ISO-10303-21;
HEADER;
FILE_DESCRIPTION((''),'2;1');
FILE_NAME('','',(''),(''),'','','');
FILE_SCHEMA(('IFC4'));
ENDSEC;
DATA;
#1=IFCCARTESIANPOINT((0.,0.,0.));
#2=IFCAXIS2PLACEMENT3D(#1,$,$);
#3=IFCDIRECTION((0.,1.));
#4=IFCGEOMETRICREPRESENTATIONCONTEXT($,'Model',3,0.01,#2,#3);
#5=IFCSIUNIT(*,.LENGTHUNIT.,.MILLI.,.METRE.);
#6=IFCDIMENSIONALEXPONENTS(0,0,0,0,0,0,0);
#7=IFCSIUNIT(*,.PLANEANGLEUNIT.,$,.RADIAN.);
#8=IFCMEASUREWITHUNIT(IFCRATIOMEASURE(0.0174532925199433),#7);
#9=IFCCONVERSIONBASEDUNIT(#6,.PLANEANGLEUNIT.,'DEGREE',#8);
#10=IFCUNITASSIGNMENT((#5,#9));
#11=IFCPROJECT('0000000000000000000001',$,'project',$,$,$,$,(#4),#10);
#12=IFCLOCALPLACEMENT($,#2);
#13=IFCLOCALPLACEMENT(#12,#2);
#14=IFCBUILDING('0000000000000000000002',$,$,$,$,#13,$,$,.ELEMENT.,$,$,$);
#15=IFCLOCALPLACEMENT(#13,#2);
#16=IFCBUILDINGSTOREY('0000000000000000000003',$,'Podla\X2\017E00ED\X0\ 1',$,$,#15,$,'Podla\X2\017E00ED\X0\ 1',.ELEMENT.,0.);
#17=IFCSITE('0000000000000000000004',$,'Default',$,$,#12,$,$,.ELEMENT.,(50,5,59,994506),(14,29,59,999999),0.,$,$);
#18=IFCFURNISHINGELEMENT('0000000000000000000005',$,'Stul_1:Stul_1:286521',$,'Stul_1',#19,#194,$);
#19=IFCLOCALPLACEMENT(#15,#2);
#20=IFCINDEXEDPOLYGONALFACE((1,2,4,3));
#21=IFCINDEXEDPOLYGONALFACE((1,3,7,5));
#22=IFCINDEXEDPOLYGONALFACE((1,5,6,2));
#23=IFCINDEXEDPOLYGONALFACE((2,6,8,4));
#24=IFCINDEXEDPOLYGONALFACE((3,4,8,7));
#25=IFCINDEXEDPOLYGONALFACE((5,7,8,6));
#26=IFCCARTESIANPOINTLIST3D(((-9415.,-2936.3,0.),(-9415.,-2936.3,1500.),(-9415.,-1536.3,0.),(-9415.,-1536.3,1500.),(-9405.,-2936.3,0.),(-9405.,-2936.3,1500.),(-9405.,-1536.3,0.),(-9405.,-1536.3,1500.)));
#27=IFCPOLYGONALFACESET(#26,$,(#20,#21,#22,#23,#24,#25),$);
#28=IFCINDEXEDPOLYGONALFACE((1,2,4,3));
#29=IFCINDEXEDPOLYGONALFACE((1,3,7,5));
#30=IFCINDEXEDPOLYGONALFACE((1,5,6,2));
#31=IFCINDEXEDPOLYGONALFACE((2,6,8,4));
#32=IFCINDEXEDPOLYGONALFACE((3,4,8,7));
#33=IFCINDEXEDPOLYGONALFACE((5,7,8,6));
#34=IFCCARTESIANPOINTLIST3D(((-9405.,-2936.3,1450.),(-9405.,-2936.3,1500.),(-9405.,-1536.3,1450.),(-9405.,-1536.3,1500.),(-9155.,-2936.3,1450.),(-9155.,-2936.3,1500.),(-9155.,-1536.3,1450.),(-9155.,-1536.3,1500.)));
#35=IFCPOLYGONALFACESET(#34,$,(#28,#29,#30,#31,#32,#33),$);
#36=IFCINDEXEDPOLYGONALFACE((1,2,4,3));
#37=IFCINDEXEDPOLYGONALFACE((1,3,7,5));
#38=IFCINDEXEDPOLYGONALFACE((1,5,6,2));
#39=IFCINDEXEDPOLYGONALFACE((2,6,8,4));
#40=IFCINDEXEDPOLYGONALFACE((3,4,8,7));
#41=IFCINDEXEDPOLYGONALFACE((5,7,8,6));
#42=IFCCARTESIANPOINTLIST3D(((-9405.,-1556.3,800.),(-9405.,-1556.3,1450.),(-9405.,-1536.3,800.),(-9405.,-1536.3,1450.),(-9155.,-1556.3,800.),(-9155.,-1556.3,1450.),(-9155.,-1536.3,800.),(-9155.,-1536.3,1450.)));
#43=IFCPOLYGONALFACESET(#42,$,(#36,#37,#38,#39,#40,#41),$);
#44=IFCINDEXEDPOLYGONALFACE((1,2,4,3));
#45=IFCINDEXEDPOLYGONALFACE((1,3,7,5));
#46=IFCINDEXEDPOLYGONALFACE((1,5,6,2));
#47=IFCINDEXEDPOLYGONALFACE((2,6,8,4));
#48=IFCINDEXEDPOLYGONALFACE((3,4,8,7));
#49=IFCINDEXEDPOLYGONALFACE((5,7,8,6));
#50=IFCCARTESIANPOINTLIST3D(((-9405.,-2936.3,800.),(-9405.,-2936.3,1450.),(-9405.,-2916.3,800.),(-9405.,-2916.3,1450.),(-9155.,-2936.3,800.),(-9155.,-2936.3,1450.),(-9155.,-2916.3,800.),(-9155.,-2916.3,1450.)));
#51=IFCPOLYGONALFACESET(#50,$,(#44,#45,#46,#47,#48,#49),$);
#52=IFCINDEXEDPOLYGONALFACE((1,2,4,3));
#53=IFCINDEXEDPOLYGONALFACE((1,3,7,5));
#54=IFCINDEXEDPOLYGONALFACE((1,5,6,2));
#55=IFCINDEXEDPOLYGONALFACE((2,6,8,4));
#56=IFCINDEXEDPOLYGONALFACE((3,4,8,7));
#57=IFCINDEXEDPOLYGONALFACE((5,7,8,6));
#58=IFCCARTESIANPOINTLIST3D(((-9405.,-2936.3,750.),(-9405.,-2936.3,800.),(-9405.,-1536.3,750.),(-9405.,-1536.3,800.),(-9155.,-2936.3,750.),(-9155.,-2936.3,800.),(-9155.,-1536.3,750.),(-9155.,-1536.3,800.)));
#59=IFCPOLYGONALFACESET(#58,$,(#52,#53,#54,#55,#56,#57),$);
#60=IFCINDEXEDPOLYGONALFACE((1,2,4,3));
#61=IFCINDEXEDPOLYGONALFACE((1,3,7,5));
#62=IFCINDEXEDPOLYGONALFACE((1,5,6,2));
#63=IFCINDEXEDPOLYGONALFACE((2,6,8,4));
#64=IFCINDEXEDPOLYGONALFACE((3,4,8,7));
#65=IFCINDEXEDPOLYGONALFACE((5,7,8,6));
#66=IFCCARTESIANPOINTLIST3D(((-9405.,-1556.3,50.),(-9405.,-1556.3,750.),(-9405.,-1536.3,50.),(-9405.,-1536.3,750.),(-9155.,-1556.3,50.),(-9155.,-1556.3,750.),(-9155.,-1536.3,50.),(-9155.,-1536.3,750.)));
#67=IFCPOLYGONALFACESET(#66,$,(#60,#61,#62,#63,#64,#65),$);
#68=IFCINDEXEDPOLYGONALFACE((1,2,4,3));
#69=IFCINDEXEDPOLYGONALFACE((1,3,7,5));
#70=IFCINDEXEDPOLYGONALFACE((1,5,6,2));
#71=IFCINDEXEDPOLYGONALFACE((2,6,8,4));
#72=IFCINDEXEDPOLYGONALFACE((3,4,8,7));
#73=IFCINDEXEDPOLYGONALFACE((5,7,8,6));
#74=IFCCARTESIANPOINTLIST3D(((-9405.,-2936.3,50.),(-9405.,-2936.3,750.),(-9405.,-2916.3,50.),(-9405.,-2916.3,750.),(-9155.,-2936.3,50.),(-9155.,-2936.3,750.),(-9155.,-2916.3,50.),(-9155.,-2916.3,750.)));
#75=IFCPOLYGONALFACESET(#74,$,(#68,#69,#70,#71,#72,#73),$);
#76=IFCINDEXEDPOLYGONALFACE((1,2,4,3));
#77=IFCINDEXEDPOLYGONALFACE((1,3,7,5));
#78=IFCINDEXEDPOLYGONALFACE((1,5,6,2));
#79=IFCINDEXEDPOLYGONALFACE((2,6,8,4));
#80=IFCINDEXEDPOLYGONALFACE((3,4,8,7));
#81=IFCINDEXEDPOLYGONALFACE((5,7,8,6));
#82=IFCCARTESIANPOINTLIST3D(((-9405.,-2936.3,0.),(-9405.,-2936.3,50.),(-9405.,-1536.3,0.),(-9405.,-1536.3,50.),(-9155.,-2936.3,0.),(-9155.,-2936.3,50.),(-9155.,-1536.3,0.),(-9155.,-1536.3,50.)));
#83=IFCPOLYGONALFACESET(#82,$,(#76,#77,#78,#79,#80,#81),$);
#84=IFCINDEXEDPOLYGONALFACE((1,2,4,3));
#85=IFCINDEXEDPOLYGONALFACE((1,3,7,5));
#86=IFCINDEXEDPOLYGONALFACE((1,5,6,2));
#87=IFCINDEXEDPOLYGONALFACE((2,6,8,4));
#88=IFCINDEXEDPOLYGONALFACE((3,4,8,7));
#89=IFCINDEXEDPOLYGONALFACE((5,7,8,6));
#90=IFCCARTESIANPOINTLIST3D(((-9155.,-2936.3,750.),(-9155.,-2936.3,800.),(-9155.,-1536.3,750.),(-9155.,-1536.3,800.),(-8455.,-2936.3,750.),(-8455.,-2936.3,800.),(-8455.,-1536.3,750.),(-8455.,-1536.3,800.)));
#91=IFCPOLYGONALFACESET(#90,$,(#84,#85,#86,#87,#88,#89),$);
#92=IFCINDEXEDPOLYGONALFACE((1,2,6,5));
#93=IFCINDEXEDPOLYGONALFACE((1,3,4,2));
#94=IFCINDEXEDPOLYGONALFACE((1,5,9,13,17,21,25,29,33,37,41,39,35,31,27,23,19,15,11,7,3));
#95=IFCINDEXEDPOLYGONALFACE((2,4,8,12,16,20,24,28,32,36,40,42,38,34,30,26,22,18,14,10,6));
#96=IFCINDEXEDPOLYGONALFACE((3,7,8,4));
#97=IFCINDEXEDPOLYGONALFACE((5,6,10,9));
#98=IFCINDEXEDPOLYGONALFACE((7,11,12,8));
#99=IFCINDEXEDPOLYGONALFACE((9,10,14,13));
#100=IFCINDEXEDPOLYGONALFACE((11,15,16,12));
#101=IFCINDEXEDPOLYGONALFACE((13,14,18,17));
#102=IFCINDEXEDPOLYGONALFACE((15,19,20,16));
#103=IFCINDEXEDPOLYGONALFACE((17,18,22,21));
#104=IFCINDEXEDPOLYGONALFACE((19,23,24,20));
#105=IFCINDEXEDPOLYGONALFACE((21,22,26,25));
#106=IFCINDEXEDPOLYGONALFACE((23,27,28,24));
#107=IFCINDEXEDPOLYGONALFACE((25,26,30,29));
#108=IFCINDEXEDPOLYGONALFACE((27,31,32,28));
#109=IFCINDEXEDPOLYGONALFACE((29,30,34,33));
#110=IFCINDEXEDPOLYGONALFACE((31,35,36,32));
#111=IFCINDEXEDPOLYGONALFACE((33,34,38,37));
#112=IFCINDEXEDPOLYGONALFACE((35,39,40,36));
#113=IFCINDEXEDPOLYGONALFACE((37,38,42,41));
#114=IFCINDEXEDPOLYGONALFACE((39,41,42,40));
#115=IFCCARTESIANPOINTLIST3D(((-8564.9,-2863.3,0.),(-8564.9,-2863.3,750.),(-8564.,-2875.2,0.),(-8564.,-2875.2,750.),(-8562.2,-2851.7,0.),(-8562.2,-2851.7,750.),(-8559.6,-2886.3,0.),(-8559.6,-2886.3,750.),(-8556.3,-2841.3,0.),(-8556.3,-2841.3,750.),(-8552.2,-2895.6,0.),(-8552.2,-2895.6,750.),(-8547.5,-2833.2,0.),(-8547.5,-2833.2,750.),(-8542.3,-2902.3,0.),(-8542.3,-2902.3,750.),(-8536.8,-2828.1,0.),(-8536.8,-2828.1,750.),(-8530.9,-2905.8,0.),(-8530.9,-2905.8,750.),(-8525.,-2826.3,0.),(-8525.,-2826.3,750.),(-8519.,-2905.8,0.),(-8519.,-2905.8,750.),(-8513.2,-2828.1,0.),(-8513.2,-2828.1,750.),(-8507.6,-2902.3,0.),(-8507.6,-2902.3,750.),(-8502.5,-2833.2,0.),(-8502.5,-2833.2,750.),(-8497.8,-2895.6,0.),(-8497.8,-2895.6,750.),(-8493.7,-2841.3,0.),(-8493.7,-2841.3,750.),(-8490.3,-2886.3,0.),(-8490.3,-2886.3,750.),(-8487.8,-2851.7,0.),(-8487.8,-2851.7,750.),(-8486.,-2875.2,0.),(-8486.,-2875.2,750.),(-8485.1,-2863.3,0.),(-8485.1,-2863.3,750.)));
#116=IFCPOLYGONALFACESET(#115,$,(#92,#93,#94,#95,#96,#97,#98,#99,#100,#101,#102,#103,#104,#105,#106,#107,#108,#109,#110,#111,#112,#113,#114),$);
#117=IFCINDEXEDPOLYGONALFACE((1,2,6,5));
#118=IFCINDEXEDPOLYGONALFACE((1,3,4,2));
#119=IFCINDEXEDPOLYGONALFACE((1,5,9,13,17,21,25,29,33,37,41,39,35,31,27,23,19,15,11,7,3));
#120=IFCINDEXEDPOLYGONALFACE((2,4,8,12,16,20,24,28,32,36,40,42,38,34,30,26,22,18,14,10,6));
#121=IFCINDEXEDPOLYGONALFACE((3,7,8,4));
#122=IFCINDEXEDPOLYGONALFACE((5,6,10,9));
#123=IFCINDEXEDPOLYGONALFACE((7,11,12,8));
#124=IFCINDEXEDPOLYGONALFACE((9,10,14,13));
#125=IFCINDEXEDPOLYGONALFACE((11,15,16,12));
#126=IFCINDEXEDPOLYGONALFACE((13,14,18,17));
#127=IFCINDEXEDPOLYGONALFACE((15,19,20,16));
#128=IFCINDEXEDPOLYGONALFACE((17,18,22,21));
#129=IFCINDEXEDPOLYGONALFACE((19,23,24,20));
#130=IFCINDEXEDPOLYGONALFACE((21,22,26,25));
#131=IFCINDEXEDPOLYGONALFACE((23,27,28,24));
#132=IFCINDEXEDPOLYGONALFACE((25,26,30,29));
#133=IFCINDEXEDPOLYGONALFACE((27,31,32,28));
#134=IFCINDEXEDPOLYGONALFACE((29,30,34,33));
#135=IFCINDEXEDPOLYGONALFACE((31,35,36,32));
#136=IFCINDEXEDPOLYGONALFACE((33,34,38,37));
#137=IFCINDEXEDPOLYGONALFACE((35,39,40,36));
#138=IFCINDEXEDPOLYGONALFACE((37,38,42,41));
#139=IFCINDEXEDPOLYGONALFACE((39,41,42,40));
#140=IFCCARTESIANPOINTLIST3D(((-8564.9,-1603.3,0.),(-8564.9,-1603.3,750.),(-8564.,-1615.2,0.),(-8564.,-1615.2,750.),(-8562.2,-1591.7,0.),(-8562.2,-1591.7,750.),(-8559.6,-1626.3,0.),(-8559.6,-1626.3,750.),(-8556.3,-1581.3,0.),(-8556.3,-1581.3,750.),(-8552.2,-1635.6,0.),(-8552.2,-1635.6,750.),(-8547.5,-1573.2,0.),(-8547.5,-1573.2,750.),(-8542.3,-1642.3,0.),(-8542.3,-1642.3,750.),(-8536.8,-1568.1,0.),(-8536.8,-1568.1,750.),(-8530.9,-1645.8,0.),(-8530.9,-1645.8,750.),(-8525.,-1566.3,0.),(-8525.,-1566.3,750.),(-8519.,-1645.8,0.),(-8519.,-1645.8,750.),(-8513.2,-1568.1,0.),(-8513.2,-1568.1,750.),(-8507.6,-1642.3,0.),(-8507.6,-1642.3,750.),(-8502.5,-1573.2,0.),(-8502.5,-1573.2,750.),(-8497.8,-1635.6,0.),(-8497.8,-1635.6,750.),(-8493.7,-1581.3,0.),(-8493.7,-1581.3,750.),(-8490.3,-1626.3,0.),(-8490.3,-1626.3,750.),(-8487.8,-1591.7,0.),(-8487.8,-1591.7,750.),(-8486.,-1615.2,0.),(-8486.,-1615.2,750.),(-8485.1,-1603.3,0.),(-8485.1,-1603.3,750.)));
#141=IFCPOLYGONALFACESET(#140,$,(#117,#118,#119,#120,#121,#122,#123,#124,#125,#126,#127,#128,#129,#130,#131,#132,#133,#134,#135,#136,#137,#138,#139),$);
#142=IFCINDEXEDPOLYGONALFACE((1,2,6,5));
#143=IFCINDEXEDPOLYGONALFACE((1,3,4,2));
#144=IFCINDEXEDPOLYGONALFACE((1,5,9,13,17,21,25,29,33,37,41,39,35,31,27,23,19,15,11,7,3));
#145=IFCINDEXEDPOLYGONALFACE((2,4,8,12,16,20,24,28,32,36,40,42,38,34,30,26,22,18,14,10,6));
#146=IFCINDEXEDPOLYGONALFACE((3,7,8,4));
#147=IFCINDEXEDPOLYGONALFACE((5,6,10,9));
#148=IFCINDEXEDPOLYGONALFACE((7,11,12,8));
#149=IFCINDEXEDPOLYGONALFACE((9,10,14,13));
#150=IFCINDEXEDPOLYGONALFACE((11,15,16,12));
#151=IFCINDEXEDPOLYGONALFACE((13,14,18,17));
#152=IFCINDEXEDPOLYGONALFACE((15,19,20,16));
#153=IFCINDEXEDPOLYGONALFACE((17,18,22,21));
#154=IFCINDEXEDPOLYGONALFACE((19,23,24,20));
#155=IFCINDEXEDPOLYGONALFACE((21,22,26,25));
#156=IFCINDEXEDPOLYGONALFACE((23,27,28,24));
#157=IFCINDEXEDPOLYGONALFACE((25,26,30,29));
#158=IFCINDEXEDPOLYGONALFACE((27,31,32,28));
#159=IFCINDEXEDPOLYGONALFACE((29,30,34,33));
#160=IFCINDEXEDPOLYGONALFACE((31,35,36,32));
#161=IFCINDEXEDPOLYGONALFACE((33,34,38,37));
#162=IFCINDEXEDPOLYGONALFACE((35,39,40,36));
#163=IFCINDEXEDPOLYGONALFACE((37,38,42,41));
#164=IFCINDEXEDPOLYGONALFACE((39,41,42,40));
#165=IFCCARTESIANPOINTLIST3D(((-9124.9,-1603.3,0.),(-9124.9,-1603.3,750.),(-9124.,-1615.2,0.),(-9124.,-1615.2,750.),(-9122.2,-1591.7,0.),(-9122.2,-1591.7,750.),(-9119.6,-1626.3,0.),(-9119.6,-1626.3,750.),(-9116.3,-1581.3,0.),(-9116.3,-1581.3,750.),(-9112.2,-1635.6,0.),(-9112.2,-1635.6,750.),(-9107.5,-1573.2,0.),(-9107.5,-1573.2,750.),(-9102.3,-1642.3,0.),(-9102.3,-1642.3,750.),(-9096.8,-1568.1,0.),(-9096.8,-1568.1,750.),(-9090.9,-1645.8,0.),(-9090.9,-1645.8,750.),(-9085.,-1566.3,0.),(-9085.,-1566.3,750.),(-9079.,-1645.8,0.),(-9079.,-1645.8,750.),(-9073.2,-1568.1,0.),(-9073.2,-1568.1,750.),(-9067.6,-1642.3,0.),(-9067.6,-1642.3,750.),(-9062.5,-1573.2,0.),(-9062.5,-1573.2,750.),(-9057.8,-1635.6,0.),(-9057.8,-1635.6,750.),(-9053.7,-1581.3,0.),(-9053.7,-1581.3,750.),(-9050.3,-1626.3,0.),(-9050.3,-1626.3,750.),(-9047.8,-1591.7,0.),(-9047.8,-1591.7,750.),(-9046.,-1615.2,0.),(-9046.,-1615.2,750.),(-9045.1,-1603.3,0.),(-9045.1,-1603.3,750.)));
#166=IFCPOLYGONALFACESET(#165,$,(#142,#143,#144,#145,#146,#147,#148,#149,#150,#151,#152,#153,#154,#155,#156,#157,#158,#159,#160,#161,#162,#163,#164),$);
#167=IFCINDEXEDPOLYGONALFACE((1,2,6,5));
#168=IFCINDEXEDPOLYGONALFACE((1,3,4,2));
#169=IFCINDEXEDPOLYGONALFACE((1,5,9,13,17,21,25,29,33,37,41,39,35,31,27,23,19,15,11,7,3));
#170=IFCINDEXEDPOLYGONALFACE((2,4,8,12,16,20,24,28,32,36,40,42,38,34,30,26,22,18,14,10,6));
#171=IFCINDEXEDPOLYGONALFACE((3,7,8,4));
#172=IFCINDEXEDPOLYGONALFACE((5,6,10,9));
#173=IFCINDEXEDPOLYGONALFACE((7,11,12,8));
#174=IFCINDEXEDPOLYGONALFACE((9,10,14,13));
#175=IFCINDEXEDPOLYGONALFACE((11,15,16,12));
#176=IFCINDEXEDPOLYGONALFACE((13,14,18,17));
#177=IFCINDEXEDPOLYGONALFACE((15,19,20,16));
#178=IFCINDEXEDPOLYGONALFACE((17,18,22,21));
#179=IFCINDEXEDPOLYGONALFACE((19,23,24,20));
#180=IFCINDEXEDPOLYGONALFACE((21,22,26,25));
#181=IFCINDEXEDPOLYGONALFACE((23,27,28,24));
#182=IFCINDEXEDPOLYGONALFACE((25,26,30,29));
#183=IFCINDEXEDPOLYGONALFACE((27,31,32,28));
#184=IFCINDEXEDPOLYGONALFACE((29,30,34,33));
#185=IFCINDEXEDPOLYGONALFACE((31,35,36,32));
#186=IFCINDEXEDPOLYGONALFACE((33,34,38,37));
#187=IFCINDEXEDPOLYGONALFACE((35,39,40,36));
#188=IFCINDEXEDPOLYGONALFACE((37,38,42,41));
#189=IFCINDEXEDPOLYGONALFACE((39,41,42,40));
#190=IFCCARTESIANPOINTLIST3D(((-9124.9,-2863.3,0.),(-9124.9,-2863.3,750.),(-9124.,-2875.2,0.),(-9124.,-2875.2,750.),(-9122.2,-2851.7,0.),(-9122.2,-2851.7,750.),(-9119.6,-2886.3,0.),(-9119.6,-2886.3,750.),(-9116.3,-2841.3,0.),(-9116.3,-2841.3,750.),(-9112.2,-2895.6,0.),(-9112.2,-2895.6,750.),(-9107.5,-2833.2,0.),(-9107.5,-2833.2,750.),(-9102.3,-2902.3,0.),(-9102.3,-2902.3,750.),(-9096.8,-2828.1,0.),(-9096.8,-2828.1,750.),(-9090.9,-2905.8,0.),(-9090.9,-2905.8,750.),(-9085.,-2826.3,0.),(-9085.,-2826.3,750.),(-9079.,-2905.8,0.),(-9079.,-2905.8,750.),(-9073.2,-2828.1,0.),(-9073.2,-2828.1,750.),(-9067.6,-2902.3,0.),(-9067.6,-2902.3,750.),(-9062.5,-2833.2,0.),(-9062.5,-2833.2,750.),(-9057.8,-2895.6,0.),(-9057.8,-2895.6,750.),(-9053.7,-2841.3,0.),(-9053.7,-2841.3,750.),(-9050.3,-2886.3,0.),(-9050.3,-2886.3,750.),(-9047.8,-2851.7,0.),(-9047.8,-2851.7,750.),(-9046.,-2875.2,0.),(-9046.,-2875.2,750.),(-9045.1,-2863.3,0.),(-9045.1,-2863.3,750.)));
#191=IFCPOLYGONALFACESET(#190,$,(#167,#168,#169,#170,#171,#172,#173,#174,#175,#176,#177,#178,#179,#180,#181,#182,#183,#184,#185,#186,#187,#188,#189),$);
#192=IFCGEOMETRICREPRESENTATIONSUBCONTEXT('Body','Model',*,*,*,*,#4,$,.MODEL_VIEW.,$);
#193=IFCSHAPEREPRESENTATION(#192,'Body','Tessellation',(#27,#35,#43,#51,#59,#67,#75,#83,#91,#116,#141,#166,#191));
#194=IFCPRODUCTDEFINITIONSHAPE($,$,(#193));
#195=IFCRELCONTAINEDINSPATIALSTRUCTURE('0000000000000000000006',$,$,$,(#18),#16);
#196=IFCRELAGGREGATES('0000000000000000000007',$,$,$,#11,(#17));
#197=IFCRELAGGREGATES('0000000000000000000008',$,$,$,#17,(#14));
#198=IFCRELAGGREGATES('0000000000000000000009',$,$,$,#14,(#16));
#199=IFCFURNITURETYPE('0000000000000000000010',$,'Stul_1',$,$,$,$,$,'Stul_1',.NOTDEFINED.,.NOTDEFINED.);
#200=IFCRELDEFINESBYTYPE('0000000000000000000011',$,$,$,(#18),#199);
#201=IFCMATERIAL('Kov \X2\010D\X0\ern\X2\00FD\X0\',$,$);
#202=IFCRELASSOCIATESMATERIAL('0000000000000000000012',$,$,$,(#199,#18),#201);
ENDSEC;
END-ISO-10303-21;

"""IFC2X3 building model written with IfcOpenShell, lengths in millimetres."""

from ifc_helpers import new_model, entity, si_unit, converted_unit, direction, frame, frame_2d, origin, origin_2d_with_axis, place, context, subcontext, project, spatial, rectangle, circle, extrude, source, transform, mapped, material, type_object, type_shapes, element, save


model = new_model("IFC2X3")

# Units and contexts
model_context = context("Model", 3, precision=0.01, world=origin(), true_north=direction((0.0, 1.0)))
body_context = subcontext(model_context, "Body", "Model", "MODEL_VIEW")
ifc_project = project(units=[si_unit("LENGTHUNIT", "METRE", prefix="MILLI"), converted_unit("PLANEANGLEUNIT", "DEGREE", entity("IfcRatioMeasure", 0.0174532925199433), si_unit("PLANEANGLEUNIT", "RADIAN"), dimensions=[0, 0, 0, 0, 0, 0, 0])], contexts=[model_context])

# Site, building, storey
site_placement = place(None, origin())
site = spatial("IfcSite", under=ifc_project, at=site_placement, Name="Default", CompositionType="ELEMENT", RefLatitude=(50, 5, 59, 994506), RefLongitude=(14, 29, 59, 999999), RefElevation=0.0)
building_placement = place(site_placement, origin())
building = spatial("IfcBuilding", under=site, at=building_placement, CompositionType="ELEMENT")
storey_placement = place(building_placement, origin())
storey = spatial("IfcBuildingStorey", under=building, at=storey_placement, Name="Podlaží 1", LongName="Podlaží 1", CompositionType="ELEMENT", Elevation=0.0)

# Furnishing element
ifc_material_1 = material(Name="Kov černý")
furniture_type = type_object("IfcFurnitureType", Name="Stul_1", ElementType="Stul_1", material=ifc_material_1)
shared_shape_1 = source(origin(), body_context, "Body", "SweptSolid", [
    extrude(rectangle(XDim=1400.0, YDim=10.0, at=origin_2d_with_axis()), frame((0.0, 605.0, 0.0), z_axis=(0.0, 0.0, 1.0), x_axis=(-1.0, 0.0, 0.0)), (0.0, 0.0, 1.0), 1500.0),
    extrude(rectangle(XDim=1400.0, YDim=250.0, at=frame_2d((0.0, 0.0), x_axis=(1.0, 0.0))), frame((0.0, 475.0, 1450.0), z_axis=(0.0, 0.0, 1.0), x_axis=(-1.0, 0.0, 0.0)), (0.0, 0.0, 1.0), 50.0),
    extrude(rectangle(XDim=20.0, YDim=250.0, at=origin_2d_with_axis()), frame((690.0, 475.0, 800.0), z_axis=(0.0, 0.0, 1.0), x_axis=(-1.0, 0.0, 0.0)), (0.0, 0.0, 1.0), 650.0),
    extrude(rectangle(XDim=20.0, YDim=250.0, at=frame_2d((0.0, 0.0), x_axis=(1.0, 0.0))), frame((-690.0, 475.0, 800.0), z_axis=(0.0, 0.0, 1.0), x_axis=(-1.0, 0.0, 0.0)), (0.0, 0.0, 1.0), 650.0),
    extrude(rectangle(XDim=1400.0, YDim=250.0, at=origin_2d_with_axis()), frame((0.0, 475.0, 750.0), z_axis=(0.0, 0.0, 1.0), x_axis=(-1.0, 0.0, 0.0)), (0.0, 0.0, 1.0), 50.0),
    extrude(rectangle(XDim=20.0, YDim=250.0, at=origin_2d_with_axis()), frame((690.0, 475.0, 50.0), z_axis=(0.0, 0.0, 1.0), x_axis=(-1.0, 0.0, 0.0)), (0.0, 0.0, 1.0), 700.0),
    extrude(rectangle(XDim=20.0, YDim=250.0, at=frame_2d((0.0, 0.0), x_axis=(1.0, 0.0))), frame((-690.0, 475.0, 50.0), z_axis=(0.0, 0.0, 1.0), x_axis=(-1.0, 0.0, 0.0)), (0.0, 0.0, 1.0), 700.0),
    extrude(rectangle(XDim=1400.0, YDim=250.0, at=origin_2d_with_axis()), frame((0.0, 475.0, 0.0), z_axis=(0.0, 0.0, 1.0), x_axis=(-1.0, 0.0, 0.0)), (0.0, 0.0, 1.0), 50.0),
    extrude(rectangle(XDim=1400.0, YDim=700.0, at=origin_2d_with_axis()), frame((0.0, 0.0, 750.0), z_axis=(0.0, 0.0, 1.0), x_axis=(-1.0, 0.0, 0.0)), (0.0, 0.0, 1.0), 50.0),
    extrude(circle(Radius=40.0, at=frame_2d((0.0, 0.0), x_axis=(1.0, 0.0))), frame((-630.0, -280.0, 0.0)), (0.0, 0.0, 1.0), 750.0),
    extrude(circle(Radius=40.0, at=frame_2d((0.0, 0.0), x_axis=(1.0, 0.0))), frame((630.0, -280.0, 0.0)), (0.0, 0.0, 1.0), 750.0),
    extrude(circle(Radius=40.0, at=frame_2d((0.0, 0.0), x_axis=(1.0, 0.0))), frame((630.0, 280.0, 0.0)), (0.0, 0.0, 1.0), 750.0),
    extrude(circle(Radius=40.0, at=frame_2d((0.0, 0.0), x_axis=(1.0, 0.0))), frame((-630.0, 280.0, 0.0)), (0.0, 0.0, 1.0), 750.0),
])
type_shapes(furniture_type, [shared_shape_1])
for number, where, z_axis, x_axis, name in (
    (1, (-8805.0, -2236.3, 0.0), (0.0, 0.0, 1.0), (0.0, 1.0, 0.0), "Stul_1:Stul_1:286521"),
):
    element("IfcFurnishingElement", number, at=place(storey_placement, frame(where, z_axis=z_axis, x_axis=x_axis)), inside=storey, type_object=furniture_type, material=ifc_material_1, Name=name, ObjectType="Stul_1", context=body_context, shape_type="MappedRepresentation", body=[
        mapped(shared_shape_1, transform((0.0, 0.0, 0.0), scale=1.0)),
    ])

save(model, "model.ifc")
